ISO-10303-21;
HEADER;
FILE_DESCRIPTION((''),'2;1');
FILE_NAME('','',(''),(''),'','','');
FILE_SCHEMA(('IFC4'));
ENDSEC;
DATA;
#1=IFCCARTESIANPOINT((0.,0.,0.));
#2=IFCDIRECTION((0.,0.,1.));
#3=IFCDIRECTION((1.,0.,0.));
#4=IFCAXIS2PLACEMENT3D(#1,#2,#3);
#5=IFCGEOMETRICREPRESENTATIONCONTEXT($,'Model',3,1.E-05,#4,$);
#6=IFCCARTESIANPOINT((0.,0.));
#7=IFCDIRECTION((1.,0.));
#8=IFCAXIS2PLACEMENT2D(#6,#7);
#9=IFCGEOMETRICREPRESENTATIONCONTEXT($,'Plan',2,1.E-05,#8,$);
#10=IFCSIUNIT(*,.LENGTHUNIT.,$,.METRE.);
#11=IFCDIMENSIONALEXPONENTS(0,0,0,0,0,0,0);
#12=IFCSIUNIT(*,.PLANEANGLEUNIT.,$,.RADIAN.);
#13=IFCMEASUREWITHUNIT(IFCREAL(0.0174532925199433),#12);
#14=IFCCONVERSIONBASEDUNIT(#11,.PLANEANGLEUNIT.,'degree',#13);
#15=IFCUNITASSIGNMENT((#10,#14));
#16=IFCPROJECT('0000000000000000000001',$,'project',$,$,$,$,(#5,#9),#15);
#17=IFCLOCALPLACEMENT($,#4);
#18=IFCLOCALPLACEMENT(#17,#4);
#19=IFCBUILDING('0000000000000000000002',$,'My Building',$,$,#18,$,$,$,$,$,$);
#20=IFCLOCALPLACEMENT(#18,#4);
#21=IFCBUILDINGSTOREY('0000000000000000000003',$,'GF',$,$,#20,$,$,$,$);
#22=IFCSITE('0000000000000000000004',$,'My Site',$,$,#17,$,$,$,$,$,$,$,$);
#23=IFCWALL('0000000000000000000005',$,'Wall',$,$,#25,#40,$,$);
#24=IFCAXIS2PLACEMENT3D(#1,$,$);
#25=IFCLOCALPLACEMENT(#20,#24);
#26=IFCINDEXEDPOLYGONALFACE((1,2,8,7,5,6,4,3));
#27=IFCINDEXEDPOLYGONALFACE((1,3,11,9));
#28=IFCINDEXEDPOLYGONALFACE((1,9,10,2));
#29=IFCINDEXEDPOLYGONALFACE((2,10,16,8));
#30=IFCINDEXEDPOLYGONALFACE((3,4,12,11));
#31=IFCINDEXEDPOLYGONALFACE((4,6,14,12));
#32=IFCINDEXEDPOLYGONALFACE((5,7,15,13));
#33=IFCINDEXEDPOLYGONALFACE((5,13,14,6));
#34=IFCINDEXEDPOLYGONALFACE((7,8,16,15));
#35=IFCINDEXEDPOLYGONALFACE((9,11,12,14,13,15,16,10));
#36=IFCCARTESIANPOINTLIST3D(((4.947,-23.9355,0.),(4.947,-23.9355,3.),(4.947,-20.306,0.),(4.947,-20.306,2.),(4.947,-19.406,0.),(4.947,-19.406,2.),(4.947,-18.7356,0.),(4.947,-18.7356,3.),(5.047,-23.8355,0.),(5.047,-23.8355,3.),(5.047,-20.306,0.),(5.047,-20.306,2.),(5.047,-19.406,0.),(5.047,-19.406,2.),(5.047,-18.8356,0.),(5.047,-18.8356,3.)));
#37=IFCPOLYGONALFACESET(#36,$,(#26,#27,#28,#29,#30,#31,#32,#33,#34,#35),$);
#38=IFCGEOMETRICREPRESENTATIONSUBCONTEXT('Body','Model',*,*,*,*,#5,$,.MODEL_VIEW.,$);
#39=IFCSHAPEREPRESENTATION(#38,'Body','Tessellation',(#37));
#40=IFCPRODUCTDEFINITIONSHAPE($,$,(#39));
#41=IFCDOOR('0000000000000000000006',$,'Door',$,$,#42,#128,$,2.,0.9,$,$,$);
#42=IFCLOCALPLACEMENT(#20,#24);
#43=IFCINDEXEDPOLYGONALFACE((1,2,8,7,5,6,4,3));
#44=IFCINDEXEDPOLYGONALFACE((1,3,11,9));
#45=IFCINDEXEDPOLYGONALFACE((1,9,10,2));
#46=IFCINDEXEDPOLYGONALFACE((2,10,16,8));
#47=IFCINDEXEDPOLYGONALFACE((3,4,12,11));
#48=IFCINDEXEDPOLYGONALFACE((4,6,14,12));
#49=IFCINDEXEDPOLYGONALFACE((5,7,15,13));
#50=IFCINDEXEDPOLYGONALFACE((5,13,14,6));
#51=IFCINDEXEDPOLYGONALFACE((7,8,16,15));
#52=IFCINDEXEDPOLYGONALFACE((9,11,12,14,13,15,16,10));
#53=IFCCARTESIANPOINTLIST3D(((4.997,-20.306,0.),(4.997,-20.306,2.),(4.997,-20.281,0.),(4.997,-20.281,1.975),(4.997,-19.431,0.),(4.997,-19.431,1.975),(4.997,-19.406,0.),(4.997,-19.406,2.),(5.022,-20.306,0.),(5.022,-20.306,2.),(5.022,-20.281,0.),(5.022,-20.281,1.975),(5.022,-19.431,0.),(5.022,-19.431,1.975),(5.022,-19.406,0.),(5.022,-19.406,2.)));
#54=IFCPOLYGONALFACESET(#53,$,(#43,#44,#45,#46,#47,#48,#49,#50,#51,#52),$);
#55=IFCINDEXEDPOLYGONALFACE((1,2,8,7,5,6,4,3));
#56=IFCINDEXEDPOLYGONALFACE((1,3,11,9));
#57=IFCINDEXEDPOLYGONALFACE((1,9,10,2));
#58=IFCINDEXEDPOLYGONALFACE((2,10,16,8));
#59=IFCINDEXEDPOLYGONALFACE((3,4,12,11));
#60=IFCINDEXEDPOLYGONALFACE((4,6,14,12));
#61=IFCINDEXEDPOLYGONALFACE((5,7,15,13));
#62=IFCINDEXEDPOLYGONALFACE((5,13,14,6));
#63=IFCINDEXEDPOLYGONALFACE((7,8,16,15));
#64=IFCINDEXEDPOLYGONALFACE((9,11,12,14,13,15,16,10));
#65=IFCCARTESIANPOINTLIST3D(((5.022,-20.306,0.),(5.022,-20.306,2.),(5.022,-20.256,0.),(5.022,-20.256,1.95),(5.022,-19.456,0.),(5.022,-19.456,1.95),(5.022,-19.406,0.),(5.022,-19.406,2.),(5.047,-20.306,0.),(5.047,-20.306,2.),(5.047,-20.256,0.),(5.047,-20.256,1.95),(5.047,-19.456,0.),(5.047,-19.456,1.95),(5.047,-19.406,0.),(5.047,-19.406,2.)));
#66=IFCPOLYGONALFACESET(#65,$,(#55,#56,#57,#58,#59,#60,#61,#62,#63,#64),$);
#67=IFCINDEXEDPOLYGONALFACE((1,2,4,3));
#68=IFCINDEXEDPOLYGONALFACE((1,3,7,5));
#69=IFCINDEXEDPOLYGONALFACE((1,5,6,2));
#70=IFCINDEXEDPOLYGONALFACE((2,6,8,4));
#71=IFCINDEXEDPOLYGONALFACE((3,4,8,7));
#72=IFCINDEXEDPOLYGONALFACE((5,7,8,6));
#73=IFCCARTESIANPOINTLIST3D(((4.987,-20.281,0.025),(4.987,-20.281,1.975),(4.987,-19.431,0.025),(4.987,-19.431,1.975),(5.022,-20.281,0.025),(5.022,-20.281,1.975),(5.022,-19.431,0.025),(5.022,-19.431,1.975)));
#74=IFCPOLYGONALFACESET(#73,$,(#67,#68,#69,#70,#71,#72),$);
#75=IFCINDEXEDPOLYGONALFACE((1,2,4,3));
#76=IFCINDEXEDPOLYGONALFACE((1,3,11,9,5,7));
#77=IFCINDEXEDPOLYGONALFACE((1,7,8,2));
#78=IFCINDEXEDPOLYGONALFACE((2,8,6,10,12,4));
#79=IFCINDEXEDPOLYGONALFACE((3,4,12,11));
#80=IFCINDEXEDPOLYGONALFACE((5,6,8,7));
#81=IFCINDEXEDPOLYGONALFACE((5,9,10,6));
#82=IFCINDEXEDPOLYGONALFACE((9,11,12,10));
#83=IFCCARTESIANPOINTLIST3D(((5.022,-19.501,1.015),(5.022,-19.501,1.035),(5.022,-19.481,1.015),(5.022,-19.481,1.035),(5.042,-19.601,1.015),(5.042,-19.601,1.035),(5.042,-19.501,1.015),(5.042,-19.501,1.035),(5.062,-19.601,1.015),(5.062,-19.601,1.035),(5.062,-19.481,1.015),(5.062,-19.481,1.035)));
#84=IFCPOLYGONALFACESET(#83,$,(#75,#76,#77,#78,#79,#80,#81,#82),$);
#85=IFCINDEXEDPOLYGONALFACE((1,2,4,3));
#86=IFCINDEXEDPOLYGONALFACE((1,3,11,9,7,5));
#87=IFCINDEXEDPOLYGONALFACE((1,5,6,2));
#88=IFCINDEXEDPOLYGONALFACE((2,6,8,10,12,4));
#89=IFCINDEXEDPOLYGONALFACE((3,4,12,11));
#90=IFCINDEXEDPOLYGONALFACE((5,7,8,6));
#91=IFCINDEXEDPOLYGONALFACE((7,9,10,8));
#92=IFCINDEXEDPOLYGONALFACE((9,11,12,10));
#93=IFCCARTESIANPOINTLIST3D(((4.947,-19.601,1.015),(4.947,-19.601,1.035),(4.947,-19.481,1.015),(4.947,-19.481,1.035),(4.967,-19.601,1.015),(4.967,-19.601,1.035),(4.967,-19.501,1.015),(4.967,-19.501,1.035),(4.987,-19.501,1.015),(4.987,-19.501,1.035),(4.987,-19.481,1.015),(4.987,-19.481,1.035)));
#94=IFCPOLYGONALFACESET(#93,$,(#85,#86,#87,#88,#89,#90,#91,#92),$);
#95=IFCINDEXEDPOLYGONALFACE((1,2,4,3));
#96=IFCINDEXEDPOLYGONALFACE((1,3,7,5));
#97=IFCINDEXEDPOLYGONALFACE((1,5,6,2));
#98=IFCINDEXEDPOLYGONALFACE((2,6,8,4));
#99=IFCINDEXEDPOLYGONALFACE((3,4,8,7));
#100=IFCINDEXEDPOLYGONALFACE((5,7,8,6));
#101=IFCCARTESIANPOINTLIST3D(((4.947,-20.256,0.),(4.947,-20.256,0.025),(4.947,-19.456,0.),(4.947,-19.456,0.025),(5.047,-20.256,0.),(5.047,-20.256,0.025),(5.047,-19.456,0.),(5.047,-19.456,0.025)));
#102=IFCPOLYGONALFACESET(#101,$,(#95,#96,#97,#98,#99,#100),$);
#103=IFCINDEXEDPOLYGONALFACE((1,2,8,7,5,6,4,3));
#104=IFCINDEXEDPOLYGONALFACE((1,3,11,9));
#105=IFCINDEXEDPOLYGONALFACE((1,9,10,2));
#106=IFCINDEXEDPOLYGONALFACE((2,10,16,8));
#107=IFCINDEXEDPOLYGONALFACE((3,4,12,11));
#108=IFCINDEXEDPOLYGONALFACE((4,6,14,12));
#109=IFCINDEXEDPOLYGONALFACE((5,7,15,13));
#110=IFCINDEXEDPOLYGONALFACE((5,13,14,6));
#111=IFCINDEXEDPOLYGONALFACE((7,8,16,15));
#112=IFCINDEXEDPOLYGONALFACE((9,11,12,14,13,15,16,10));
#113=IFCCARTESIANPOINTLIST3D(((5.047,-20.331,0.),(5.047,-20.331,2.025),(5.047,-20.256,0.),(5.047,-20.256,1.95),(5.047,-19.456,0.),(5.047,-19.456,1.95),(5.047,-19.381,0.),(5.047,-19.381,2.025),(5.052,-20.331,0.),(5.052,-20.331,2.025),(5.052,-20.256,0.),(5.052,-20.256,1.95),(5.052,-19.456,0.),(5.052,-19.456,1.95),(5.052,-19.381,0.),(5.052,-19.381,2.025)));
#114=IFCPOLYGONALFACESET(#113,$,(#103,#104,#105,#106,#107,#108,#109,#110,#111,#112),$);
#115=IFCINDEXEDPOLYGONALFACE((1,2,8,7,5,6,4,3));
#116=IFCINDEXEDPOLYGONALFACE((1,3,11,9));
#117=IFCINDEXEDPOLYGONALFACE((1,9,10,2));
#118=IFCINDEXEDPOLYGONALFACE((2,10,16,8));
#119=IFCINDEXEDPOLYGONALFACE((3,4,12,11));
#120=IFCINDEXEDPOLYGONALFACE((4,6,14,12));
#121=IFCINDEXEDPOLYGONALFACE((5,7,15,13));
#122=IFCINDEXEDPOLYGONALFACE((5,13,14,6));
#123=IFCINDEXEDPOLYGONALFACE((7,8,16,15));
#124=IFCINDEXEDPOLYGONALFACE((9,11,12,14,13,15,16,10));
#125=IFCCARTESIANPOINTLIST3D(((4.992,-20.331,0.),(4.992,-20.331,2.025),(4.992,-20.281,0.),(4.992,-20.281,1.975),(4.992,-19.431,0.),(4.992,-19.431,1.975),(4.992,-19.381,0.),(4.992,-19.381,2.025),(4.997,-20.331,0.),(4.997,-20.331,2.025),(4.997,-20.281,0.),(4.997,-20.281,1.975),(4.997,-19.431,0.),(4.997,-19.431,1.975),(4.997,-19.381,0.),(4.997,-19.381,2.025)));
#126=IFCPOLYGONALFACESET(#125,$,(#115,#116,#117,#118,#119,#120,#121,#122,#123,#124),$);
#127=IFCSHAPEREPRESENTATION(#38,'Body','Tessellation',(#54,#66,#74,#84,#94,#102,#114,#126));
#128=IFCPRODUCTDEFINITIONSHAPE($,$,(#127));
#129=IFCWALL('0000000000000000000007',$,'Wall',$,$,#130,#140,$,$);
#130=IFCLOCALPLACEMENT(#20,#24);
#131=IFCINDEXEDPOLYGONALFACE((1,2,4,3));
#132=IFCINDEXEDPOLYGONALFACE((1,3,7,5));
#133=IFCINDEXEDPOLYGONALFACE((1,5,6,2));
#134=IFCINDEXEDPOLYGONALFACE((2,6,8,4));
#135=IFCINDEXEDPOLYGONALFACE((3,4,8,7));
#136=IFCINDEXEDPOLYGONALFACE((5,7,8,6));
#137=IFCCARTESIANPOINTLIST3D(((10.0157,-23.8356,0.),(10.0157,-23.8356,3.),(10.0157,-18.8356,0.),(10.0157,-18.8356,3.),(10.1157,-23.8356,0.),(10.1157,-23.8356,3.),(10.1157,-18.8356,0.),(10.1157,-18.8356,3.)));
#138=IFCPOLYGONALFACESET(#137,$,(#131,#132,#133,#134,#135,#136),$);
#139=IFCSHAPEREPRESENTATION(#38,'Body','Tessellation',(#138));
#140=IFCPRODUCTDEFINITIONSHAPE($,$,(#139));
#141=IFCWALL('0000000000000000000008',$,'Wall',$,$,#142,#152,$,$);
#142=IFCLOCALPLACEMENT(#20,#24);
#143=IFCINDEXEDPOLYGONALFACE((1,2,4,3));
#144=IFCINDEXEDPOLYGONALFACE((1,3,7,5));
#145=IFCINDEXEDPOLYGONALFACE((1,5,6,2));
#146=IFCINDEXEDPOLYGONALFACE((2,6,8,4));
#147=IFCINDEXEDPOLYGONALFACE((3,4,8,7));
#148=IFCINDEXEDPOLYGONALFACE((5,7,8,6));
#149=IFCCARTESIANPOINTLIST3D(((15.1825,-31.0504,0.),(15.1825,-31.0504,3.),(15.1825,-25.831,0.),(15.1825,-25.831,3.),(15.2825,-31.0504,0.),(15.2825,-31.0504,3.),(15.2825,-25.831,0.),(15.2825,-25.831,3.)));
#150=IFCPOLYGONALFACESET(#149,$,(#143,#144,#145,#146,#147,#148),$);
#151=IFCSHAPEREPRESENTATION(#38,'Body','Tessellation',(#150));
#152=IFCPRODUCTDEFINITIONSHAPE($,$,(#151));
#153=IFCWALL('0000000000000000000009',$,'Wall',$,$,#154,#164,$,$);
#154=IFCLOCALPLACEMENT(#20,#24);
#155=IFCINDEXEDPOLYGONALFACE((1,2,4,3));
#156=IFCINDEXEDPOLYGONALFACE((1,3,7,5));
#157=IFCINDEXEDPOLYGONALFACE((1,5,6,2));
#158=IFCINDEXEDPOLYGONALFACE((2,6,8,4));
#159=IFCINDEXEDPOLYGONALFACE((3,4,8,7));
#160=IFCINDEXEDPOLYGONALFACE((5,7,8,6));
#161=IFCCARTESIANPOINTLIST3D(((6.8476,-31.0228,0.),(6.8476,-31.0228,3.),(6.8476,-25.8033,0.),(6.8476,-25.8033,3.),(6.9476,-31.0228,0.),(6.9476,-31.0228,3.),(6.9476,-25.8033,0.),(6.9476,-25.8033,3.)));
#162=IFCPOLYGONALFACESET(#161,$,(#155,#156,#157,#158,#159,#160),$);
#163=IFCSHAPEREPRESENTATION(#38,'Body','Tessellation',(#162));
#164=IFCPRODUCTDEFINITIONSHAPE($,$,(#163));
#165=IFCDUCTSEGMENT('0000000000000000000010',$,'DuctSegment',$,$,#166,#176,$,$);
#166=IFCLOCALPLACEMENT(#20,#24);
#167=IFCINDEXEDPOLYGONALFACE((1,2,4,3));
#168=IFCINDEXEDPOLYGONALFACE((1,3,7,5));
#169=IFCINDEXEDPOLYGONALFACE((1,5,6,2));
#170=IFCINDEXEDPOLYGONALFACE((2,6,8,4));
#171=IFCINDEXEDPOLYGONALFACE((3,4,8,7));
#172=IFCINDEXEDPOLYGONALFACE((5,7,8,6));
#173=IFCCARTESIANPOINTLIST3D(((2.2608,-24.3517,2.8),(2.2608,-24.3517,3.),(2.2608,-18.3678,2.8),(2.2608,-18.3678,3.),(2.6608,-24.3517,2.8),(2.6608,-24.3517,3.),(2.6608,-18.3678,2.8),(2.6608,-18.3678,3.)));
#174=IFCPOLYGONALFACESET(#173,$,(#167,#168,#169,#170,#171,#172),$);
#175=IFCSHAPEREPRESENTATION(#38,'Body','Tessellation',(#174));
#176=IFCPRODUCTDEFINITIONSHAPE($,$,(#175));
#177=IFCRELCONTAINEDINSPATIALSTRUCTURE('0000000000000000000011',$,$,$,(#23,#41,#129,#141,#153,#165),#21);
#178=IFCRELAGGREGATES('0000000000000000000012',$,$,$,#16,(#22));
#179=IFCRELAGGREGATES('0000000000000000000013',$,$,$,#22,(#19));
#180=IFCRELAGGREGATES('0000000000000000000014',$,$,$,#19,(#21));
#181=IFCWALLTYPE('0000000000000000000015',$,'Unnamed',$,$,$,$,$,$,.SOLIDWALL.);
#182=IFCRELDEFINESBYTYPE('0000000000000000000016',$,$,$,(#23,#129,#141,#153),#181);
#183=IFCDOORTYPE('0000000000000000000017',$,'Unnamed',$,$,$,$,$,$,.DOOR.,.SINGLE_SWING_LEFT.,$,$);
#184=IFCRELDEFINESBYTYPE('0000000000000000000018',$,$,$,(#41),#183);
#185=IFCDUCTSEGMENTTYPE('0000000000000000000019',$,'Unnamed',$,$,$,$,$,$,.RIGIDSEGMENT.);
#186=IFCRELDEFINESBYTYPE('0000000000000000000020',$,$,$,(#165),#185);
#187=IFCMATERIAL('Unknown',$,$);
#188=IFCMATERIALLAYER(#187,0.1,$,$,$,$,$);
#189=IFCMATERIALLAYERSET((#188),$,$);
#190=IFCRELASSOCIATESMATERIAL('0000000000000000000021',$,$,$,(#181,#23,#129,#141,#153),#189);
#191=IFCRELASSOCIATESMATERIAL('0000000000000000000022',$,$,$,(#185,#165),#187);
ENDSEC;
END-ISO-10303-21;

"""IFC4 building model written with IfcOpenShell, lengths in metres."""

from ifc_helpers import new_model, entity, si_unit, converted_unit, frame, origin_with_axes, origin_2d_with_axis, place, context, subcontext, project, spatial, line, indexed_curve, rectangle, outline, extrude, shape, source, transform, mapped, material, layer, layer_set, layer_usage, material_profile, profile_set, profile_usage, type_object, type_shapes, element, fill, save


model = new_model("IFC4")

# Units and contexts
model_context = context("Model", 3, precision=1e-05, world=origin_with_axes())
plan_context = context("Plan", 2, precision=1e-05, world=origin_2d_with_axis())
body_context_1 = subcontext(model_context, "Body", "Model", "MODEL_VIEW")
body_context_2 = subcontext(plan_context, "Body", "Plan", "PLAN_VIEW")
ifc_project = project(units=[si_unit("LENGTHUNIT", "METRE"), converted_unit("PLANEANGLEUNIT", "degree", entity("IfcReal", 0.0174532925199433), si_unit("PLANEANGLEUNIT", "RADIAN"), dimensions=[0, 0, 0, 0, 0, 0, 0])], contexts=[model_context, plan_context])

# Site, building, storey
site_placement = place(None, origin_with_axes())
site = spatial("IfcSite", under=ifc_project, at=site_placement, Name="My Site")
building_placement = place(site_placement, origin_with_axes())
building = spatial("IfcBuilding", under=site, at=building_placement, Name="My Building")
storey_placement = place(building_placement, origin_with_axes())
storey = spatial("IfcBuildingStorey", under=building, at=storey_placement, Name="GF")

# Shared definitions
ifc_material = material(Name="Unknown")
ifc_layer = layer(ifc_material, 0.1)
ifc_layer_set = layer_set([ifc_layer])
wall_type = type_object("IfcWallType", Name="Unnamed", PredefinedType="SOLIDWALL", material=ifc_layer_set)

# Shared definitions
shared_shape_1 = source(origin_with_axes(), body_context_1, "Body", "SweptSolid", [
    extrude(outline(indexed_curve([(0.0, 0.0), (0.9, 0.0), (0.9, 2.0), (0.0, 2.0)], segments=[line(1, 2, 3, 4, 1)])), frame((0.0, -0.6, 0.0), z_axis=(0.0, -1.0, 0.0), x_axis=(1.0, 0.0, 0.0)), (0.0, 0.0, -1.0), 1.2),
])
door_type = type_object("IfcDoorType", Name="Unnamed", OperationType="SINGLE_SWING_LEFT", PredefinedType="DOOR")
shared_shape_2 = source(origin_with_axes(), body_context_1, "Body", "SweptSolid", [
    extrude(outline(indexed_curve([(0.0, 0.0), (0.0, 2.0), (0.9, 2.0), (0.9, 0.0), (0.875, 0.0), (0.875, 1.975), (0.025, 1.975), (0.025, 0.0)], segments=[line(1, 2, 3, 4, 5, 6, 7, 8, 1)])), frame((0.0, 0.025, 0.0), z_axis=(0.0, -1.0, 0.0), x_axis=(1.0, 0.0, 0.0)), (0.0, 0.0, -1.0), 0.025),
    extrude(outline(indexed_curve([(0.0, 0.0), (0.0, 2.0), (0.9, 2.0), (0.9, 0.0), (0.85, 0.0), (0.85, 1.95), (0.05, 1.95), (0.05, 0.0)], segments=[line(1, 2, 3, 4, 5, 6, 7, 8, 1)])), frame((0.0, 0.0, 0.0), z_axis=(0.0, -1.0, 0.0), x_axis=(1.0, 0.0, 0.0)), (0.0, 0.0, -1.0), 0.025),
    extrude(outline(indexed_curve([(0.0, 0.0), (0.85, 0.0), (0.85, 0.035), (0.0, 0.035)], segments=[line(1, 2, 3, 4, 1)])), frame((0.025, 0.025, 0.025), z_axis=(0.0, 0.0, 1.0), x_axis=(1.0, 0.0, 0.0)), (0.0, 0.0, 1.0), 1.95),
    extrude(outline(indexed_curve([(0.0, 0.0), (0.0, -0.04), (-0.12, -0.04), (-0.12, -0.02), (-0.02, -0.02), (-0.02, 0.0)], segments=[line(1, 2, 3, 4, 5, 6, 1)])), frame((0.825, 0.025, 1.015), z_axis=(0.0, 0.0, 1.0), x_axis=(1.0, 0.0, 0.0)), (0.0, 0.0, 1.0), 0.02),
    extrude(outline(indexed_curve([(0.0, 0.0), (0.0, 0.04), (-0.12, 0.04), (-0.12, 0.02), (-0.02, 0.02), (-0.02, 0.0)], segments=[line(1, 2, 3, 4, 5, 6, 1)])), frame((0.825, 0.06, 1.015), z_axis=(0.0, 0.0, 1.0), x_axis=(1.0, 0.0, 0.0)), (0.0, 0.0, 1.0), 0.02),
    extrude(outline(indexed_curve([(0.0, 0.0), (0.8, 0.0), (0.8, 0.1), (0.0, 0.1)], segments=[line(1, 2, 3, 4, 1)])), frame((0.05, 0.0, 0.0), z_axis=(0.0, 0.0, 1.0), x_axis=(1.0, 0.0, 0.0)), (0.0, 0.0, 1.0), 0.025),
    extrude(outline(indexed_curve([(0.0, 0.0), (0.0, 2.025), (0.95, 2.025), (0.95, 0.0), (0.875, 0.0), (0.875, 1.95), (0.075, 1.95), (0.075, 0.0)], segments=[line(1, 2, 3, 4, 5, 6, 7, 8, 1)])), frame((-0.025, -0.005, 0.0), z_axis=(0.0, -1.0, 0.0), x_axis=(1.0, 0.0, 0.0)), (0.0, 0.0, -1.0), 0.005),
    extrude(outline(indexed_curve([(0.0, 0.0), (0.0, 2.025), (0.95, 2.025), (0.95, 0.0), (0.9, 0.0), (0.9, 1.975), (0.05, 1.975), (0.05, 0.0)], segments=[line(1, 2, 3, 4, 5, 6, 7, 8, 1)])), frame((-0.025, 0.05, 0.0), z_axis=(0.0, -1.0, 0.0), x_axis=(1.0, 0.0, 0.0)), (0.0, 0.0, -1.0), 0.005),
])
shared_shape_3 = source(origin_with_axes(), body_context_2, "Body", "Curve2D", [
    entity("IfcIndexedPolyCurve", entity("IfcCartesianPointList2D", [[0.0, 0.0], [0.0, 0.05], [0.025, 0.05], [0.025, 0.025], [0.05, 0.025], [0.05, 0.0]]), [entity("IfcLineIndex", [1, 2, 3, 4, 5, 6, 1])]),
    entity("IfcIndexedPolyCurve", entity("IfcCartesianPointList2D", [[0.9, 0.0], [0.9, 0.05], [0.875, 0.05], [0.875, 0.025], [0.85, 0.025], [0.85, 0.0]]), [entity("IfcLineIndex", [1, 2, 3, 4, 5, 6, 1])]),
    entity("IfcTrimmedCurve", entity("IfcEllipse", entity("IfcAxis2Placement2D", entity("IfcCartesianPoint", [0.06, 0.05]), entity("IfcDirection", [1.0, 0.0])), 0.815, 0.85), [entity("IfcCartesianPoint", [0.875, 0.05])], [entity("IfcCartesianPoint", [0.06, 0.9])], True, "CARTESIAN"),
    entity("IfcIndexedPolyCurve", entity("IfcCartesianPointList2D", [[0.025, 0.05], [0.06, 0.05], [0.06, 0.9], [0.025, 0.9]]), [entity("IfcLineIndex", [1, 2, 3, 4, 1])]),
])
type_shapes(door_type, [shared_shape_2, shared_shape_3])

# Wall, opening, door
ifc_layer_usage_1 = layer_usage(ifc_layer_set, "AXIS2", "POSITIVE", 0.0)
wall_1_placement = place(storey_placement, frame((5.047, -23.8355, 0.0), z_axis=(0.0, 0.0, 1.0), x_axis=(0.0, 1.0, 0.0)))
wall_1 = element("IfcWall", 1, at=wall_1_placement, inside=storey, type_object=wall_type, material=ifc_layer_usage_1, Name="Wall", context=body_context_1, shape_type="SweptSolid", body=[
    extrude(outline(indexed_curve([(0.0, 0.0), (-0.1, 0.1), (5.1, 0.1), (5.0, 0.0)], segments=[line(1, 2, 3, 4, 1)])), origin_with_axes(), (0.0, 0.0, 1.0), 3.0),
])
opening_1_placement = place(wall_1_placement, frame((3.5295, 0.0, 0.0), z_axis=(0.0, 0.0, 1.0), x_axis=(1.0, 0.0, 0.0)))
opening_1 = element("IfcOpeningElement", 2, at=opening_1_placement, cuts=wall_1, PredefinedType="OPENING", context=body_context_1, shape_type="MappedRepresentation", body=[
    mapped(shared_shape_1, transform((0.0, 0.0, 0.0), x_axis=(1.0, 0.0, 0.0), y_axis=(0.0, 1.0, 0.0), z_axis=(0.0, 0.0, 1.0), scale=1.0)),
])
door_1_placement = place(opening_1_placement, frame((0.0, 0.0, 0.0), z_axis=(0.0, 0.0, 1.0), x_axis=(1.0, 0.0, 0.0)))
door_1 = element("IfcDoor", 3, at=door_1_placement, inside=storey, type_object=door_type, Name="Door", OverallHeight=2.0, OverallWidth=0.9, shapes=[
    shape(body_context_1, "Body", "MappedRepresentation", [mapped(shared_shape_2, transform((0.0, 0.0, 0.0), x_axis=(1.0, 0.0, 0.0), y_axis=(0.0, 1.0, 0.0), z_axis=(0.0, 0.0, 1.0), scale=1.0))]),
    shape(body_context_2, "Body", "MappedRepresentation", [mapped(shared_shape_3, transform((0.0, 0.0, 0.0), x_axis=(1.0, 0.0, 0.0), y_axis=(0.0, 1.0, 0.0), z_axis=(0.0, 0.0, 1.0), scale=1.0))]),
])
fill(opening_1, door_1)

# Walls
ifc_layer_usage_2 = layer_usage(ifc_layer_set, "AXIS2", "POSITIVE", 0.0)
wall_2_placement = place(storey_placement, frame((10.0157, -18.8356, 0.0), z_axis=(0.0, 0.0, 1.0), x_axis=(0.0, -1.0, 0.0)))
element("IfcWall", 4, at=wall_2_placement, inside=storey, type_object=wall_type, material=ifc_layer_usage_2, Name="Wall", context=body_context_1, shape_type="SweptSolid", body=[
    extrude(outline(indexed_curve([(0.0, 0.0), (0.0, 0.1), (5.0, 0.1), (5.0, 0.0)], segments=[line(1, 2, 3, 4, 1)])), origin_with_axes(), (0.0, 0.0, 1.0), 3.0),
])
ifc_layer_usage_3 = layer_usage(ifc_layer_set, "AXIS2", "POSITIVE", 0.0)
wall_3_placement = place(storey_placement, frame((15.1825, -25.831, 0.0), z_axis=(0.0, 0.0, 1.0), x_axis=(0.0, -1.0, 0.0)))
element("IfcWall", 5, at=wall_3_placement, inside=storey, type_object=wall_type, material=ifc_layer_usage_3, Name="Wall", context=body_context_1, shape_type="SweptSolid", body=[
    extrude(outline(indexed_curve([(0.0, 0.0), (0.0, 0.1), (5.2194, 0.1), (5.2194, 0.0)], segments=[line(1, 2, 3, 4, 1)])), origin_with_axes(), (0.0, 0.0, 1.0), 3.0),
])
ifc_layer_usage_4 = layer_usage(ifc_layer_set, "AXIS2", "POSITIVE", 0.0)
wall_4_placement = place(storey_placement, frame((6.8476, -25.8033, 0.0), z_axis=(0.0, 0.0, 1.0), x_axis=(0.0, -1.0, 0.0)))
element("IfcWall", 6, at=wall_4_placement, inside=storey, type_object=wall_type, material=ifc_layer_usage_4, Name="Wall", context=body_context_1, shape_type="SweptSolid", body=[
    extrude(outline(indexed_curve([(0.0, 0.0), (0.0, 0.1), (5.2195, 0.1), (5.2195, 0.0)], segments=[line(1, 2, 3, 4, 1)])), origin_with_axes(), (0.0, 0.0, 1.0), 3.0),
])

# Duct segment
ifc_material_profile_1 = material_profile(ifc_material, rectangle(XDim=0.4, YDim=0.2))
ifc_profile_set_1 = profile_set([ifc_material_profile_1])
ifc_profile_usage_1 = profile_usage(ifc_profile_set_1, cardinal=5)
duct_segment_type = type_object("IfcDuctSegmentType", Name="Unnamed", PredefinedType="RIGIDSEGMENT", material=ifc_profile_set_1)
duct_segment_1_placement = place(storey_placement, frame((2.4608, -24.3517, 2.9), z_axis=(0.0, 1.0, 0.0), x_axis=(-1.0, 0.0, 0.0)))
element("IfcDuctSegment", 7, at=duct_segment_1_placement, inside=storey, type_object=duct_segment_type, material=ifc_profile_usage_1, Name="DuctSegment", context=body_context_1, shape_type="SweptSolid", body=[
    extrude(rectangle(XDim=0.4, YDim=0.2), origin_with_axes(), (0.0, 0.0, 1.0), 5.9839),
])

save(model, "model.ifc")
